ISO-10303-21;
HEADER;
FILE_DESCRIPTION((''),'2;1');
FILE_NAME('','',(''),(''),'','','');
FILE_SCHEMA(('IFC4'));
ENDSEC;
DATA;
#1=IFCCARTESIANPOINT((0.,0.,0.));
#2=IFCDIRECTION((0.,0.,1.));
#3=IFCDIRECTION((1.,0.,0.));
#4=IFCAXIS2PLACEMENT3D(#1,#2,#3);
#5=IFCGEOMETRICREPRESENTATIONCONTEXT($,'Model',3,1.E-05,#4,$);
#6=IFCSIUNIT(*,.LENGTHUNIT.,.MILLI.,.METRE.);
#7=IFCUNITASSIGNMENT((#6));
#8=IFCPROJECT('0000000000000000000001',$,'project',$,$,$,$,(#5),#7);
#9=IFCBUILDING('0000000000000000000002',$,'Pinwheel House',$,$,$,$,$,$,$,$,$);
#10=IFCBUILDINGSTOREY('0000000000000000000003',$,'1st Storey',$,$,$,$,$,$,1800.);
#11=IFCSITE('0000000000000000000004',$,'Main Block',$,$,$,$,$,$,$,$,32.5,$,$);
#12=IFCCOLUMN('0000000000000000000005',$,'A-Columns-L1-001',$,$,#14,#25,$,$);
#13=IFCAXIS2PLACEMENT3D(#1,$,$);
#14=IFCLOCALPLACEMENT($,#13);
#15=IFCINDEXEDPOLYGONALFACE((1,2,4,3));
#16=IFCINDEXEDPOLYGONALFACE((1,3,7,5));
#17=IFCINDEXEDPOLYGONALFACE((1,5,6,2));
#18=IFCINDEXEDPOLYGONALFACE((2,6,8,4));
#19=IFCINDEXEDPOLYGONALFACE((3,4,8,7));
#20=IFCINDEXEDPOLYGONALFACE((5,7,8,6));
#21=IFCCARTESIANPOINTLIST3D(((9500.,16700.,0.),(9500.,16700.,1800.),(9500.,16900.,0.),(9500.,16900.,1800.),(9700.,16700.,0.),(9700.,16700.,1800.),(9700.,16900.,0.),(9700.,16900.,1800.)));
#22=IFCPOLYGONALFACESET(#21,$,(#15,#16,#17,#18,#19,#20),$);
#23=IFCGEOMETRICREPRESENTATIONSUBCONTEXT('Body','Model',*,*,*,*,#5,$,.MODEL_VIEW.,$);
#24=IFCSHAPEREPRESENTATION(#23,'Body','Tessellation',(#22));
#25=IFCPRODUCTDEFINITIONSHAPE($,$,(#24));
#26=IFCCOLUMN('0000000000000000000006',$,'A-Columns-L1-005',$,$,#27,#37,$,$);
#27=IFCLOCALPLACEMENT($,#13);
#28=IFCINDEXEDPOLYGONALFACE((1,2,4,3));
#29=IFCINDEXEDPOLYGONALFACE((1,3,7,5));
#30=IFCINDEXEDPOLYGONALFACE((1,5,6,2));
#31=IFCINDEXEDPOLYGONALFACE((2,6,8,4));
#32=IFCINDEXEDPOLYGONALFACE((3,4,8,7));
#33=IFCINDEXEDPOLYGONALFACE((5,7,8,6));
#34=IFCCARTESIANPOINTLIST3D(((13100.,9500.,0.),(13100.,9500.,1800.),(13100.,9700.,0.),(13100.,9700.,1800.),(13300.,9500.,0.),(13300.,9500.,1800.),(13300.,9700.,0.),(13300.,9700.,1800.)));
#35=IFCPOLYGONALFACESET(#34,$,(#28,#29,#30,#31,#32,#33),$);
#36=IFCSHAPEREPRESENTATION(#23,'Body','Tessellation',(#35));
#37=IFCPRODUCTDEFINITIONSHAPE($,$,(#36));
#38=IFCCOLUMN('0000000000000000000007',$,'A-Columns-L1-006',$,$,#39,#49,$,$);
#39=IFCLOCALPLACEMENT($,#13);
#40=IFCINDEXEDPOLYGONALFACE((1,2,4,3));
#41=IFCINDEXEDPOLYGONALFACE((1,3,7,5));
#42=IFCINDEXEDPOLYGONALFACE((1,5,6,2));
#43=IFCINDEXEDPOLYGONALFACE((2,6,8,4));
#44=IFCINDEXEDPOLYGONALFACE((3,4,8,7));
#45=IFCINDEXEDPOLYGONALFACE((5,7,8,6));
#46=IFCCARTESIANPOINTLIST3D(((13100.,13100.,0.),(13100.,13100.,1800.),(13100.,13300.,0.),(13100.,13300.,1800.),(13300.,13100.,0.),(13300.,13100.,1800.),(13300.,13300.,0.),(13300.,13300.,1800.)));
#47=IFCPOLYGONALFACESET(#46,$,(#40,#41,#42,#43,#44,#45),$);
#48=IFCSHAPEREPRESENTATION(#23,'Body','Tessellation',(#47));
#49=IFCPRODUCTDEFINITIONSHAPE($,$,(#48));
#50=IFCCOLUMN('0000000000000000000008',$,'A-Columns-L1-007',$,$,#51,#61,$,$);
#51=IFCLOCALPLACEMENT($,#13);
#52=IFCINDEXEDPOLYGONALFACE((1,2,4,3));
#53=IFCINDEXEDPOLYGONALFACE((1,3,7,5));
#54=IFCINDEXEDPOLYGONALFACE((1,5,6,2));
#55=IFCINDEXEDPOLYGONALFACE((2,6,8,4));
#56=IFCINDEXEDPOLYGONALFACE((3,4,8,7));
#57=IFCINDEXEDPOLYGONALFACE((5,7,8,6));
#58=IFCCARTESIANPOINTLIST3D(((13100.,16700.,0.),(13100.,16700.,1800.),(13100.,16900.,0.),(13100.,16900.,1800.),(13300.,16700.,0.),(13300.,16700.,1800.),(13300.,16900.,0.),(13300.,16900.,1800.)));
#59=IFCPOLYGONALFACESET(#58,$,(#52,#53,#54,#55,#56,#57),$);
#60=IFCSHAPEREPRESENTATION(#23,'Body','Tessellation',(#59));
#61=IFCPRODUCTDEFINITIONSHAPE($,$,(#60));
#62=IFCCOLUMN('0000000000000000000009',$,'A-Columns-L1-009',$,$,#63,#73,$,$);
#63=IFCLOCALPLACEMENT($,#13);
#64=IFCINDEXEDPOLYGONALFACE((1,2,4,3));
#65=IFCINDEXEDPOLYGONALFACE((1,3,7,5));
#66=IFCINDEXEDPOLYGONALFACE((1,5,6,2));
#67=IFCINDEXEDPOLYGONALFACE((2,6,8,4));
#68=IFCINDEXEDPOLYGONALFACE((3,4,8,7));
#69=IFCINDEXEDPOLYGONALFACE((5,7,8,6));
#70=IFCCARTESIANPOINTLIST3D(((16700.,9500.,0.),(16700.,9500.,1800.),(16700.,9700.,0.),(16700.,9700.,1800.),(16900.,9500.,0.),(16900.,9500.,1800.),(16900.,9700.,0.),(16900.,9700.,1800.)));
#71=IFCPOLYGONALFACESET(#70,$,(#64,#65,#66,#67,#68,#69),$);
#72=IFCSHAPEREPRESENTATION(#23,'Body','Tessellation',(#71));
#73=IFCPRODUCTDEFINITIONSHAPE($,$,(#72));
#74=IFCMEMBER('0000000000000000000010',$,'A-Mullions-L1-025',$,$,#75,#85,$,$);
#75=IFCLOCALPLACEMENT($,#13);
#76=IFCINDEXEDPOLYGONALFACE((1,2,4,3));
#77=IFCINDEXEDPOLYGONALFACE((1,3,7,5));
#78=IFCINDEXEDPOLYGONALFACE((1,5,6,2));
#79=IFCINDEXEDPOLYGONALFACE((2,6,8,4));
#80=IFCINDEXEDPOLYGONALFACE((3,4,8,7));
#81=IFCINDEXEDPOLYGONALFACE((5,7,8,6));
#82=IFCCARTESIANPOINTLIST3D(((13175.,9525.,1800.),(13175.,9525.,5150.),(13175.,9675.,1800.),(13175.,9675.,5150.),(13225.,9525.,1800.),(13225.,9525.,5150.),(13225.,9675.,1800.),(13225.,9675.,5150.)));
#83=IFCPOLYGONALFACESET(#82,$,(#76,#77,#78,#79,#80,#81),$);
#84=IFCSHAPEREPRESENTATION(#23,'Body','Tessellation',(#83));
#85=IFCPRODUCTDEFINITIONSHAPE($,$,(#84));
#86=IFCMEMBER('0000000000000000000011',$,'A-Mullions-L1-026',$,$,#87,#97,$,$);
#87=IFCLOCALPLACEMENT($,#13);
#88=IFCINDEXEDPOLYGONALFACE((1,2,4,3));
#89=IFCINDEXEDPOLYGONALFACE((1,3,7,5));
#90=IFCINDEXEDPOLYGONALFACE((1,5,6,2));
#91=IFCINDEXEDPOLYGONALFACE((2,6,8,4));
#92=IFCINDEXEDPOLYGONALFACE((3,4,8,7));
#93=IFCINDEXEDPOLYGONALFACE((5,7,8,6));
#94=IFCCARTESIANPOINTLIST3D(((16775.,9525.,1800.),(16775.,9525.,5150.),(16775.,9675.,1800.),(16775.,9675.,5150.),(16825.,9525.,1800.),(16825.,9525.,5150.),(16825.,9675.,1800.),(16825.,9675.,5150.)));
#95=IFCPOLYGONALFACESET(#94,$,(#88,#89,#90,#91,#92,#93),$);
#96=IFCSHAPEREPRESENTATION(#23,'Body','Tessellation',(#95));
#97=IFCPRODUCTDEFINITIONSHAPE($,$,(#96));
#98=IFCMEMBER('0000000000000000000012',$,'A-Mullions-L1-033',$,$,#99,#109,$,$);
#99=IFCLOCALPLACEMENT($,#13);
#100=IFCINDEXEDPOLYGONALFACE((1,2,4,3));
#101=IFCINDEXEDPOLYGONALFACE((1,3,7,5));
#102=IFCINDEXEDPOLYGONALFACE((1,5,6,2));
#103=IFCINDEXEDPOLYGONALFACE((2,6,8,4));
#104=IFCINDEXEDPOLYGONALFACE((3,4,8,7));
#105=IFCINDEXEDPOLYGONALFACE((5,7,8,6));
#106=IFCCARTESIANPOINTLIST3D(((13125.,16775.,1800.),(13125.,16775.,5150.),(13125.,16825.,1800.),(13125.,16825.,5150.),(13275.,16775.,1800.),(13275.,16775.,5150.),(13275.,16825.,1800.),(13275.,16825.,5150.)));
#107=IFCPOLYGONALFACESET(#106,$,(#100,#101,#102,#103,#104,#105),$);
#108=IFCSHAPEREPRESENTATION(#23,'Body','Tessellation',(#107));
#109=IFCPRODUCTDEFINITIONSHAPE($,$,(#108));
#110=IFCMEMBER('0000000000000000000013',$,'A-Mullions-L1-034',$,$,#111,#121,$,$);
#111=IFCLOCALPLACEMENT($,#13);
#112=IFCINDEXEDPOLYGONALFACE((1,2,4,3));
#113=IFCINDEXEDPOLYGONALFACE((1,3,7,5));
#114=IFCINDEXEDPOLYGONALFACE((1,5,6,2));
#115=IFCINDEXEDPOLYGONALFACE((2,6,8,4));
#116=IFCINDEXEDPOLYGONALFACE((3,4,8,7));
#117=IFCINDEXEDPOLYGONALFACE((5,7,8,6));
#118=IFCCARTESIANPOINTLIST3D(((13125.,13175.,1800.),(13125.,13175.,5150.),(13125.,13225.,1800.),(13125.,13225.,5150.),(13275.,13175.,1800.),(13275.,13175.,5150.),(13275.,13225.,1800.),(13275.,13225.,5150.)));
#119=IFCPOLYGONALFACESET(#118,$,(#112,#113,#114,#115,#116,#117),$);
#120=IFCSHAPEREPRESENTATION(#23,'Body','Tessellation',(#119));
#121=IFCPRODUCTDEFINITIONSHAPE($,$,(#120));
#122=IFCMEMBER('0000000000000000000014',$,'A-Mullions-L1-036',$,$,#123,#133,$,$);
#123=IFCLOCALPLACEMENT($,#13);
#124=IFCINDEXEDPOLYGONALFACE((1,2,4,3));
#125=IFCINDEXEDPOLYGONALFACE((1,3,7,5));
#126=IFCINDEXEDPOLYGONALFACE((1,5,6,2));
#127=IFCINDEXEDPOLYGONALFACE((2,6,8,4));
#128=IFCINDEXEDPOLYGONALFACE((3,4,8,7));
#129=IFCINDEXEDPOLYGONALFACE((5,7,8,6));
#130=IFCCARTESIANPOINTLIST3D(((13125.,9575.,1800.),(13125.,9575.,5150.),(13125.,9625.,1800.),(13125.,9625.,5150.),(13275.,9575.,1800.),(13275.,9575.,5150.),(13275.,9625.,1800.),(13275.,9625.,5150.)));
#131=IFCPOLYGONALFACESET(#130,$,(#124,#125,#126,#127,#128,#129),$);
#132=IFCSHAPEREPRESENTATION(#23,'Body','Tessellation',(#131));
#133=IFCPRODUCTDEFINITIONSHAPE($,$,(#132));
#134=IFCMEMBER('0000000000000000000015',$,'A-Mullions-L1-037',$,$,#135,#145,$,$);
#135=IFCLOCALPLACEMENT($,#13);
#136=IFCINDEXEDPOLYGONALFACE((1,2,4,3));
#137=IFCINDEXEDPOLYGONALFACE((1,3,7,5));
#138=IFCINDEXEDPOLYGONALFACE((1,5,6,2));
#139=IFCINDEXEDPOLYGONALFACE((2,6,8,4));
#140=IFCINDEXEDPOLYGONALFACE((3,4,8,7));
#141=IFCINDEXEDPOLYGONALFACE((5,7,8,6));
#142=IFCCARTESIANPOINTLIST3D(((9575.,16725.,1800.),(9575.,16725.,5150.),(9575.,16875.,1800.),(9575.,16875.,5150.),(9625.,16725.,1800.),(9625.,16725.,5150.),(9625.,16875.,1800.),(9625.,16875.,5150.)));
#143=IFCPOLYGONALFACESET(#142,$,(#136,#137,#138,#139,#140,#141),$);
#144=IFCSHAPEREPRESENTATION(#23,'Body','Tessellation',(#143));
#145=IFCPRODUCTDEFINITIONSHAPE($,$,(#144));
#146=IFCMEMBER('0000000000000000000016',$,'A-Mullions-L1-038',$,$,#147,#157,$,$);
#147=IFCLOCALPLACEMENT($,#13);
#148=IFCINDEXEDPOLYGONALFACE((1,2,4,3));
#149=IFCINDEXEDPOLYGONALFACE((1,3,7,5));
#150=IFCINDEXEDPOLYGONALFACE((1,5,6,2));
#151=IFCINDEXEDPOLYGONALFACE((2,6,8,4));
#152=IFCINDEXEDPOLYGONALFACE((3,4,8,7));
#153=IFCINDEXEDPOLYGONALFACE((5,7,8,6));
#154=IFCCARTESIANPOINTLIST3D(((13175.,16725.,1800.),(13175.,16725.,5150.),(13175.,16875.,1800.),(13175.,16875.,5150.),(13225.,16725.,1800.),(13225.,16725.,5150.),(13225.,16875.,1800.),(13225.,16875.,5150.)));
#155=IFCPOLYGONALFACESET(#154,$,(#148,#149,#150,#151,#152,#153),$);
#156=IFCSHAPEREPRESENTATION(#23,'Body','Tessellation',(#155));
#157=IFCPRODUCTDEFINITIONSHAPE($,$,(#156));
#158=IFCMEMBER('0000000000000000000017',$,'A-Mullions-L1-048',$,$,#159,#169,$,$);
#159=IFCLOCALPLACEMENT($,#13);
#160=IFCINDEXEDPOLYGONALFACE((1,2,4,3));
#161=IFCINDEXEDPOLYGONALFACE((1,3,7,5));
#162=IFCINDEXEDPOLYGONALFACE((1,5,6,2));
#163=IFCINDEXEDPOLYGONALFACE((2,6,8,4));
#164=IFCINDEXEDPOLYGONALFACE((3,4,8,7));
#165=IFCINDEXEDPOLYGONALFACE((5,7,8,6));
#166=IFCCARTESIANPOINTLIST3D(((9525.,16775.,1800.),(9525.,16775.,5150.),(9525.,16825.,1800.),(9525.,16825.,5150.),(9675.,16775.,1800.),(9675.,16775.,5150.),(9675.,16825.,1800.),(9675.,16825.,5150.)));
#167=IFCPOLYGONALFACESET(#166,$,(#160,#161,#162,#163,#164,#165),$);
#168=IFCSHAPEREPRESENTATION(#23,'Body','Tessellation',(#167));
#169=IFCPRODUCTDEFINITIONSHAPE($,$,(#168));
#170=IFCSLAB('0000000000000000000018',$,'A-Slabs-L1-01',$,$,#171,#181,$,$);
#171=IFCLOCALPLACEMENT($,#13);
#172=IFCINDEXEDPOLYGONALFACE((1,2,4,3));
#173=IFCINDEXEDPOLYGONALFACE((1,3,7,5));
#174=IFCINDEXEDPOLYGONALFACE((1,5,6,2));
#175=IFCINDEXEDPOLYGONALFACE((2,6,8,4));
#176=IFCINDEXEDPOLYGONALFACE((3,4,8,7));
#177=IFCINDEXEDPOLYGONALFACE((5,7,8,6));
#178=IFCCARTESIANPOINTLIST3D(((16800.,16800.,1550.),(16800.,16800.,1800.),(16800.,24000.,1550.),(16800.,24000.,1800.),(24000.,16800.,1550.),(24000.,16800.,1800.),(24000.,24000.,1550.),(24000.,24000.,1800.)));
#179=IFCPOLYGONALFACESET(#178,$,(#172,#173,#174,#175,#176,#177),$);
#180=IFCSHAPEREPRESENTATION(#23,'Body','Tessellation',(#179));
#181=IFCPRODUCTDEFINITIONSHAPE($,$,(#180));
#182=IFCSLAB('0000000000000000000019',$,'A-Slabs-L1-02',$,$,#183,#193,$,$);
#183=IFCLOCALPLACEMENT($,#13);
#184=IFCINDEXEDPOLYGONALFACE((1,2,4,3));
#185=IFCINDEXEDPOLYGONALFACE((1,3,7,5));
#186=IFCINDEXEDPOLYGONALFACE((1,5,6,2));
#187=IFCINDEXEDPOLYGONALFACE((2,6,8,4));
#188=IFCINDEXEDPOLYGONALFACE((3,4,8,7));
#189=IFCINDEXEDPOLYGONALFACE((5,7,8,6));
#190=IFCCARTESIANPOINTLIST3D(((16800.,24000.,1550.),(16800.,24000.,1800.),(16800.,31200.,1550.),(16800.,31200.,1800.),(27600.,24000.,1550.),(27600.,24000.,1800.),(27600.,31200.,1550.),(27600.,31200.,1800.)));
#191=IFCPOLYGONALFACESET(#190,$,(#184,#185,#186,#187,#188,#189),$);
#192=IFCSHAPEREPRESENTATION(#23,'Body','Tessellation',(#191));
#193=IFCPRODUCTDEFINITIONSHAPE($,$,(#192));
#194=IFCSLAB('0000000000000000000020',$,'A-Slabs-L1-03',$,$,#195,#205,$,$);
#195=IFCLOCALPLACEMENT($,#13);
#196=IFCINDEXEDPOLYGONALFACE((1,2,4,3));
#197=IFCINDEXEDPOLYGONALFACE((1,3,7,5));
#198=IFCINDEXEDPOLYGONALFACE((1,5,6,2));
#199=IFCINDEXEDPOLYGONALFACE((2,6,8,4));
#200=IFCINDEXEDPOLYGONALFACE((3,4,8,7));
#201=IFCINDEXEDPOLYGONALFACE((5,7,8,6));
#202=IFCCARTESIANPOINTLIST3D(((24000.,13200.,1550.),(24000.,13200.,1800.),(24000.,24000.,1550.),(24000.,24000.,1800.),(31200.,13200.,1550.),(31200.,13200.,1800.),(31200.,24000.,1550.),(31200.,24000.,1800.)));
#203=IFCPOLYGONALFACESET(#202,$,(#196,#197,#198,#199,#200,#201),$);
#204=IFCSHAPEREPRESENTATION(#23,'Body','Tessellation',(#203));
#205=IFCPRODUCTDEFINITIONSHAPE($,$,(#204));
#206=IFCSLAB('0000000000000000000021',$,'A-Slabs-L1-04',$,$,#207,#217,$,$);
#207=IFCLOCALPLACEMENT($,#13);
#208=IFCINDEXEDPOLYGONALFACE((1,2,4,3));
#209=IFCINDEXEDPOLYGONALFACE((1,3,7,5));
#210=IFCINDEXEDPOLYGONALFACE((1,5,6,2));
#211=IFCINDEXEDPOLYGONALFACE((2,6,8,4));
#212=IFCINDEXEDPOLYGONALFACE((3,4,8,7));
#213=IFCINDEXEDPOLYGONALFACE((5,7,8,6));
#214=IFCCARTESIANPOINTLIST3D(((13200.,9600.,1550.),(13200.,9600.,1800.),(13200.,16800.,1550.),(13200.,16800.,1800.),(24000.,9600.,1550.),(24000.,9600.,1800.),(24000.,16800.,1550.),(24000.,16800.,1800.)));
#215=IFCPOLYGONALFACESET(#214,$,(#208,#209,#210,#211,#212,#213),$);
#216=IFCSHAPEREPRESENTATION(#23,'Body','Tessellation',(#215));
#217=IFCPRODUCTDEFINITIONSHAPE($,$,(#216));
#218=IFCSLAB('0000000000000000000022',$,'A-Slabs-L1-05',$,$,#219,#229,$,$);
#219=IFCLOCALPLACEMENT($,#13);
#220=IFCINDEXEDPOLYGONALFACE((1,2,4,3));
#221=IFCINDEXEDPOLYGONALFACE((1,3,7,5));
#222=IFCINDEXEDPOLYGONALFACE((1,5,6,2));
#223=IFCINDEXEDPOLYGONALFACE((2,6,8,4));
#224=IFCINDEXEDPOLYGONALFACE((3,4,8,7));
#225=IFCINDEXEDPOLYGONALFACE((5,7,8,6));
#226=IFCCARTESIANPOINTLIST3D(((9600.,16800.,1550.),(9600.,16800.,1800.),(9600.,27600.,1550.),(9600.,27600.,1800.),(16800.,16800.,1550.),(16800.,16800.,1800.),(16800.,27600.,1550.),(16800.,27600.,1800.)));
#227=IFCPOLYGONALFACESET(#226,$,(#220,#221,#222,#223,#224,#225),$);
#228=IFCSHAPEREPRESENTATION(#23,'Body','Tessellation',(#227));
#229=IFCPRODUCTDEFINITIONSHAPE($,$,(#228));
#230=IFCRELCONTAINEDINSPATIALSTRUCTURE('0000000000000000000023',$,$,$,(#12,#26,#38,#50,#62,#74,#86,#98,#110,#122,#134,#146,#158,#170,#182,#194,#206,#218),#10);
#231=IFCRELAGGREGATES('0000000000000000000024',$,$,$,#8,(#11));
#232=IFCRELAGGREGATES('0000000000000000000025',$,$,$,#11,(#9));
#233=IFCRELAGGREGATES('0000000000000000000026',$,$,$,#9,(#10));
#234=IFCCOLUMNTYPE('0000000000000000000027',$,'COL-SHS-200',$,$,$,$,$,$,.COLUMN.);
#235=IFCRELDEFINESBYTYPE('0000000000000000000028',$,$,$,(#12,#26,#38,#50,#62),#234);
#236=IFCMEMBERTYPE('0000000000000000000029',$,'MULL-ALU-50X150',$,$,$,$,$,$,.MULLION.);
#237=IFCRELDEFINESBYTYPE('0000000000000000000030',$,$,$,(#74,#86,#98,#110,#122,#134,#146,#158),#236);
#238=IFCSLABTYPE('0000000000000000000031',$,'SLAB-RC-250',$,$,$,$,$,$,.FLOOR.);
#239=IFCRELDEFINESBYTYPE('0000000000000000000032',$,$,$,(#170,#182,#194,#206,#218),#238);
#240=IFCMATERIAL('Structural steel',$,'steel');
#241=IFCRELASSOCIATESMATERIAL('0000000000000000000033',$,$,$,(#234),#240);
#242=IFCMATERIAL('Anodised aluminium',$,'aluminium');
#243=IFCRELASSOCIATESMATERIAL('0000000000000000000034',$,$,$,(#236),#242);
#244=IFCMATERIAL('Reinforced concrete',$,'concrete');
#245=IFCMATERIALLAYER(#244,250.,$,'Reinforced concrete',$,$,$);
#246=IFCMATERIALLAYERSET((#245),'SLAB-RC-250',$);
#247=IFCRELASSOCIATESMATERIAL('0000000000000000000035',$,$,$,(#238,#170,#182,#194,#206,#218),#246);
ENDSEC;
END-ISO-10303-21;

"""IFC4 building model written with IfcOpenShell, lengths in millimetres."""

from ifc_helpers import new_model, si_unit, frame, origin_with_axes, place, context, subcontext, project, spatial, indexed_curve, outline, extrude, material, layer, layer_set, layer_usage, type_object, element, save


model = new_model("IFC4")

# Units and contexts
model_context = context("Model", 3, precision=1e-05, world=origin_with_axes())
body_context = subcontext(model_context, "Body", "Model", "MODEL_VIEW")
ifc_project = project(units=[si_unit("LENGTHUNIT", "METRE", prefix="MILLI")], contexts=[model_context])

# Site, building, storey
site = spatial("IfcSite", under=ifc_project, Name="Main Block", RefElevation=32.5)
building = spatial("IfcBuilding", under=site, Name="Pinwheel House")
storey = spatial("IfcBuildingStorey", under=building, Name="1st Storey", Elevation=1800.0)

# Columns
ifc_material_1 = material(Name="Structural steel", Category="steel")
column_type = type_object("IfcColumnType", Name="COL-SHS-200", PredefinedType="COLUMN", material=ifc_material_1)
for number, where, z_axis, x_axis, name in (
    (1, (9600.0, 16800.0, 0.0), (0.0, 0.0, 1.0), (1.0, 0.0, 0.0), "A-Columns-L1-001"),
    (2, (13200.0, 9600.0, 0.0), (0.0, 0.0, 1.0), (1.0, 0.0, 0.0), "A-Columns-L1-005"),
    (3, (13200.0, 13200.0, 0.0), (0.0, 0.0, 1.0), (1.0, 0.0, 0.0), "A-Columns-L1-006"),
    (4, (13200.0, 16800.0, 0.0), (0.0, 0.0, 1.0), (1.0, 0.0, 0.0), "A-Columns-L1-007"),
    (5, (16800.0, 9600.0, 0.0), (0.0, 0.0, 1.0), (1.0, 0.0, 0.0), "A-Columns-L1-009"),
):
    element("IfcColumn", number, at=place(None, frame(where, z_axis=z_axis, x_axis=x_axis)), inside=storey, type_object=column_type, Name=name, context=body_context, shape_type="SweptSolid", body=[
        extrude(outline(indexed_curve([(-100.0, -100.0), (100.0, -100.0), (100.0, 100.0), (-100.0, 100.0)])), None, (0.0, 0.0, 1.0), 1800.0),
    ])

# Members
ifc_material_2 = material(Name="Anodised aluminium", Category="aluminium")
member_type = type_object("IfcMemberType", Name="MULL-ALU-50X150", PredefinedType="MULLION", material=ifc_material_2)
for number, where, z_axis, x_axis, name in (
    (6, (13200.0, 9600.0, 1800.0), (0.0, 0.0, 1.0), (1.0, 0.0, 0.0), "A-Mullions-L1-025"),
    (7, (16800.0, 9600.0, 1800.0), (0.0, 0.0, 1.0), (1.0, 0.0, 0.0), "A-Mullions-L1-026"),
    (8, (13200.0, 16800.0, 1800.0), (0.0, 0.0, 1.0), (0.0, -1.0, 0.0), "A-Mullions-L1-033"),
    (9, (13200.0, 13200.0, 1800.0), (0.0, 0.0, 1.0), (0.0, -1.0, 0.0), "A-Mullions-L1-034"),
    (10, (13200.0, 9600.0, 1800.0), (0.0, 0.0, 1.0), (0.0, -1.0, 0.0), "A-Mullions-L1-036"),
    (11, (9600.0, 16800.0, 1800.0), (0.0, 0.0, 1.0), (1.0, 0.0, 0.0), "A-Mullions-L1-037"),
    (12, (13200.0, 16800.0, 1800.0), (0.0, 0.0, 1.0), (1.0, 0.0, 0.0), "A-Mullions-L1-038"),
    (13, (9600.0, 16800.0, 1800.0), (0.0, 0.0, 1.0), (0.0, -1.0, 0.0), "A-Mullions-L1-048"),
):
    element("IfcMember", number, at=place(None, frame(where, z_axis=z_axis, x_axis=x_axis)), inside=storey, type_object=member_type, Name=name, context=body_context, shape_type="SweptSolid", body=[
        extrude(outline(indexed_curve([(-25.0, -75.0), (25.0, -75.0), (25.0, 75.0), (-25.0, 75.0)])), None, (0.0, 0.0, 1.0), 3350.0),
    ])

# Slabs
ifc_material_3 = material(Name="Reinforced concrete", Category="concrete")
ifc_layer_1 = layer(ifc_material_3, 250.0, Name="Reinforced concrete")
ifc_layer_set_1 = layer_set([ifc_layer_1], Name="SLAB-RC-250")
ifc_layer_usage_1 = layer_usage(ifc_layer_set_1, "AXIS3", "POSITIVE", 0.0)
slab_type = type_object("IfcSlabType", Name="SLAB-RC-250", PredefinedType="FLOOR", material=ifc_layer_set_1)
slab_1_placement = place(None, frame((0.0, 0.0, 1550.0), z_axis=(0.0, 0.0, 1.0), x_axis=(1.0, 0.0, 0.0)))
element("IfcSlab", 14, at=slab_1_placement, inside=storey, type_object=slab_type, material=ifc_layer_usage_1, Name="A-Slabs-L1-01", context=body_context, shape_type="SweptSolid", body=[
    extrude(outline(indexed_curve([(16800.0, 16800.0), (24000.0, 16800.0), (24000.0, 24000.0), (16800.0, 24000.0)])), None, (0.0, 0.0, 1.0), 250.0),
])
ifc_layer_usage_2 = layer_usage(ifc_layer_set_1, "AXIS3", "POSITIVE", 0.0)
slab_2_placement = place(None, frame((0.0, 0.0, 1550.0), z_axis=(0.0, 0.0, 1.0), x_axis=(1.0, 0.0, 0.0)))
element("IfcSlab", 15, at=slab_2_placement, inside=storey, type_object=slab_type, material=ifc_layer_usage_2, Name="A-Slabs-L1-02", context=body_context, shape_type="SweptSolid", body=[
    extrude(outline(indexed_curve([(16800.0, 24000.0), (27600.0, 24000.0), (27600.0, 31200.0), (16800.0, 31200.0)])), None, (0.0, 0.0, 1.0), 250.0),
])
ifc_layer_usage_3 = layer_usage(ifc_layer_set_1, "AXIS3", "POSITIVE", 0.0)
slab_3_placement = place(None, frame((0.0, 0.0, 1550.0), z_axis=(0.0, 0.0, 1.0), x_axis=(1.0, 0.0, 0.0)))
element("IfcSlab", 16, at=slab_3_placement, inside=storey, type_object=slab_type, material=ifc_layer_usage_3, Name="A-Slabs-L1-03", context=body_context, shape_type="SweptSolid", body=[
    extrude(outline(indexed_curve([(24000.0, 13200.0), (31200.0, 13200.0), (31200.0, 24000.0), (24000.0, 24000.0)])), None, (0.0, 0.0, 1.0), 250.0),
])
ifc_layer_usage_4 = layer_usage(ifc_layer_set_1, "AXIS3", "POSITIVE", 0.0)
slab_4_placement = place(None, frame((0.0, 0.0, 1550.0), z_axis=(0.0, 0.0, 1.0), x_axis=(1.0, 0.0, 0.0)))
element("IfcSlab", 17, at=slab_4_placement, inside=storey, type_object=slab_type, material=ifc_layer_usage_4, Name="A-Slabs-L1-04", context=body_context, shape_type="SweptSolid", body=[
    extrude(outline(indexed_curve([(13200.0, 9600.0), (24000.0, 9600.0), (24000.0, 16800.0), (13200.0, 16800.0)])), None, (0.0, 0.0, 1.0), 250.0),
])
ifc_layer_usage_5 = layer_usage(ifc_layer_set_1, "AXIS3", "POSITIVE", 0.0)
slab_5_placement = place(None, frame((0.0, 0.0, 1550.0), z_axis=(0.0, 0.0, 1.0), x_axis=(1.0, 0.0, 0.0)))
element("IfcSlab", 18, at=slab_5_placement, inside=storey, type_object=slab_type, material=ifc_layer_usage_5, Name="A-Slabs-L1-05", context=body_context, shape_type="SweptSolid", body=[
    extrude(outline(indexed_curve([(9600.0, 16800.0), (16800.0, 16800.0), (16800.0, 27600.0), (9600.0, 27600.0)])), None, (0.0, 0.0, 1.0), 250.0),
])

save(model, "model.ifc")
